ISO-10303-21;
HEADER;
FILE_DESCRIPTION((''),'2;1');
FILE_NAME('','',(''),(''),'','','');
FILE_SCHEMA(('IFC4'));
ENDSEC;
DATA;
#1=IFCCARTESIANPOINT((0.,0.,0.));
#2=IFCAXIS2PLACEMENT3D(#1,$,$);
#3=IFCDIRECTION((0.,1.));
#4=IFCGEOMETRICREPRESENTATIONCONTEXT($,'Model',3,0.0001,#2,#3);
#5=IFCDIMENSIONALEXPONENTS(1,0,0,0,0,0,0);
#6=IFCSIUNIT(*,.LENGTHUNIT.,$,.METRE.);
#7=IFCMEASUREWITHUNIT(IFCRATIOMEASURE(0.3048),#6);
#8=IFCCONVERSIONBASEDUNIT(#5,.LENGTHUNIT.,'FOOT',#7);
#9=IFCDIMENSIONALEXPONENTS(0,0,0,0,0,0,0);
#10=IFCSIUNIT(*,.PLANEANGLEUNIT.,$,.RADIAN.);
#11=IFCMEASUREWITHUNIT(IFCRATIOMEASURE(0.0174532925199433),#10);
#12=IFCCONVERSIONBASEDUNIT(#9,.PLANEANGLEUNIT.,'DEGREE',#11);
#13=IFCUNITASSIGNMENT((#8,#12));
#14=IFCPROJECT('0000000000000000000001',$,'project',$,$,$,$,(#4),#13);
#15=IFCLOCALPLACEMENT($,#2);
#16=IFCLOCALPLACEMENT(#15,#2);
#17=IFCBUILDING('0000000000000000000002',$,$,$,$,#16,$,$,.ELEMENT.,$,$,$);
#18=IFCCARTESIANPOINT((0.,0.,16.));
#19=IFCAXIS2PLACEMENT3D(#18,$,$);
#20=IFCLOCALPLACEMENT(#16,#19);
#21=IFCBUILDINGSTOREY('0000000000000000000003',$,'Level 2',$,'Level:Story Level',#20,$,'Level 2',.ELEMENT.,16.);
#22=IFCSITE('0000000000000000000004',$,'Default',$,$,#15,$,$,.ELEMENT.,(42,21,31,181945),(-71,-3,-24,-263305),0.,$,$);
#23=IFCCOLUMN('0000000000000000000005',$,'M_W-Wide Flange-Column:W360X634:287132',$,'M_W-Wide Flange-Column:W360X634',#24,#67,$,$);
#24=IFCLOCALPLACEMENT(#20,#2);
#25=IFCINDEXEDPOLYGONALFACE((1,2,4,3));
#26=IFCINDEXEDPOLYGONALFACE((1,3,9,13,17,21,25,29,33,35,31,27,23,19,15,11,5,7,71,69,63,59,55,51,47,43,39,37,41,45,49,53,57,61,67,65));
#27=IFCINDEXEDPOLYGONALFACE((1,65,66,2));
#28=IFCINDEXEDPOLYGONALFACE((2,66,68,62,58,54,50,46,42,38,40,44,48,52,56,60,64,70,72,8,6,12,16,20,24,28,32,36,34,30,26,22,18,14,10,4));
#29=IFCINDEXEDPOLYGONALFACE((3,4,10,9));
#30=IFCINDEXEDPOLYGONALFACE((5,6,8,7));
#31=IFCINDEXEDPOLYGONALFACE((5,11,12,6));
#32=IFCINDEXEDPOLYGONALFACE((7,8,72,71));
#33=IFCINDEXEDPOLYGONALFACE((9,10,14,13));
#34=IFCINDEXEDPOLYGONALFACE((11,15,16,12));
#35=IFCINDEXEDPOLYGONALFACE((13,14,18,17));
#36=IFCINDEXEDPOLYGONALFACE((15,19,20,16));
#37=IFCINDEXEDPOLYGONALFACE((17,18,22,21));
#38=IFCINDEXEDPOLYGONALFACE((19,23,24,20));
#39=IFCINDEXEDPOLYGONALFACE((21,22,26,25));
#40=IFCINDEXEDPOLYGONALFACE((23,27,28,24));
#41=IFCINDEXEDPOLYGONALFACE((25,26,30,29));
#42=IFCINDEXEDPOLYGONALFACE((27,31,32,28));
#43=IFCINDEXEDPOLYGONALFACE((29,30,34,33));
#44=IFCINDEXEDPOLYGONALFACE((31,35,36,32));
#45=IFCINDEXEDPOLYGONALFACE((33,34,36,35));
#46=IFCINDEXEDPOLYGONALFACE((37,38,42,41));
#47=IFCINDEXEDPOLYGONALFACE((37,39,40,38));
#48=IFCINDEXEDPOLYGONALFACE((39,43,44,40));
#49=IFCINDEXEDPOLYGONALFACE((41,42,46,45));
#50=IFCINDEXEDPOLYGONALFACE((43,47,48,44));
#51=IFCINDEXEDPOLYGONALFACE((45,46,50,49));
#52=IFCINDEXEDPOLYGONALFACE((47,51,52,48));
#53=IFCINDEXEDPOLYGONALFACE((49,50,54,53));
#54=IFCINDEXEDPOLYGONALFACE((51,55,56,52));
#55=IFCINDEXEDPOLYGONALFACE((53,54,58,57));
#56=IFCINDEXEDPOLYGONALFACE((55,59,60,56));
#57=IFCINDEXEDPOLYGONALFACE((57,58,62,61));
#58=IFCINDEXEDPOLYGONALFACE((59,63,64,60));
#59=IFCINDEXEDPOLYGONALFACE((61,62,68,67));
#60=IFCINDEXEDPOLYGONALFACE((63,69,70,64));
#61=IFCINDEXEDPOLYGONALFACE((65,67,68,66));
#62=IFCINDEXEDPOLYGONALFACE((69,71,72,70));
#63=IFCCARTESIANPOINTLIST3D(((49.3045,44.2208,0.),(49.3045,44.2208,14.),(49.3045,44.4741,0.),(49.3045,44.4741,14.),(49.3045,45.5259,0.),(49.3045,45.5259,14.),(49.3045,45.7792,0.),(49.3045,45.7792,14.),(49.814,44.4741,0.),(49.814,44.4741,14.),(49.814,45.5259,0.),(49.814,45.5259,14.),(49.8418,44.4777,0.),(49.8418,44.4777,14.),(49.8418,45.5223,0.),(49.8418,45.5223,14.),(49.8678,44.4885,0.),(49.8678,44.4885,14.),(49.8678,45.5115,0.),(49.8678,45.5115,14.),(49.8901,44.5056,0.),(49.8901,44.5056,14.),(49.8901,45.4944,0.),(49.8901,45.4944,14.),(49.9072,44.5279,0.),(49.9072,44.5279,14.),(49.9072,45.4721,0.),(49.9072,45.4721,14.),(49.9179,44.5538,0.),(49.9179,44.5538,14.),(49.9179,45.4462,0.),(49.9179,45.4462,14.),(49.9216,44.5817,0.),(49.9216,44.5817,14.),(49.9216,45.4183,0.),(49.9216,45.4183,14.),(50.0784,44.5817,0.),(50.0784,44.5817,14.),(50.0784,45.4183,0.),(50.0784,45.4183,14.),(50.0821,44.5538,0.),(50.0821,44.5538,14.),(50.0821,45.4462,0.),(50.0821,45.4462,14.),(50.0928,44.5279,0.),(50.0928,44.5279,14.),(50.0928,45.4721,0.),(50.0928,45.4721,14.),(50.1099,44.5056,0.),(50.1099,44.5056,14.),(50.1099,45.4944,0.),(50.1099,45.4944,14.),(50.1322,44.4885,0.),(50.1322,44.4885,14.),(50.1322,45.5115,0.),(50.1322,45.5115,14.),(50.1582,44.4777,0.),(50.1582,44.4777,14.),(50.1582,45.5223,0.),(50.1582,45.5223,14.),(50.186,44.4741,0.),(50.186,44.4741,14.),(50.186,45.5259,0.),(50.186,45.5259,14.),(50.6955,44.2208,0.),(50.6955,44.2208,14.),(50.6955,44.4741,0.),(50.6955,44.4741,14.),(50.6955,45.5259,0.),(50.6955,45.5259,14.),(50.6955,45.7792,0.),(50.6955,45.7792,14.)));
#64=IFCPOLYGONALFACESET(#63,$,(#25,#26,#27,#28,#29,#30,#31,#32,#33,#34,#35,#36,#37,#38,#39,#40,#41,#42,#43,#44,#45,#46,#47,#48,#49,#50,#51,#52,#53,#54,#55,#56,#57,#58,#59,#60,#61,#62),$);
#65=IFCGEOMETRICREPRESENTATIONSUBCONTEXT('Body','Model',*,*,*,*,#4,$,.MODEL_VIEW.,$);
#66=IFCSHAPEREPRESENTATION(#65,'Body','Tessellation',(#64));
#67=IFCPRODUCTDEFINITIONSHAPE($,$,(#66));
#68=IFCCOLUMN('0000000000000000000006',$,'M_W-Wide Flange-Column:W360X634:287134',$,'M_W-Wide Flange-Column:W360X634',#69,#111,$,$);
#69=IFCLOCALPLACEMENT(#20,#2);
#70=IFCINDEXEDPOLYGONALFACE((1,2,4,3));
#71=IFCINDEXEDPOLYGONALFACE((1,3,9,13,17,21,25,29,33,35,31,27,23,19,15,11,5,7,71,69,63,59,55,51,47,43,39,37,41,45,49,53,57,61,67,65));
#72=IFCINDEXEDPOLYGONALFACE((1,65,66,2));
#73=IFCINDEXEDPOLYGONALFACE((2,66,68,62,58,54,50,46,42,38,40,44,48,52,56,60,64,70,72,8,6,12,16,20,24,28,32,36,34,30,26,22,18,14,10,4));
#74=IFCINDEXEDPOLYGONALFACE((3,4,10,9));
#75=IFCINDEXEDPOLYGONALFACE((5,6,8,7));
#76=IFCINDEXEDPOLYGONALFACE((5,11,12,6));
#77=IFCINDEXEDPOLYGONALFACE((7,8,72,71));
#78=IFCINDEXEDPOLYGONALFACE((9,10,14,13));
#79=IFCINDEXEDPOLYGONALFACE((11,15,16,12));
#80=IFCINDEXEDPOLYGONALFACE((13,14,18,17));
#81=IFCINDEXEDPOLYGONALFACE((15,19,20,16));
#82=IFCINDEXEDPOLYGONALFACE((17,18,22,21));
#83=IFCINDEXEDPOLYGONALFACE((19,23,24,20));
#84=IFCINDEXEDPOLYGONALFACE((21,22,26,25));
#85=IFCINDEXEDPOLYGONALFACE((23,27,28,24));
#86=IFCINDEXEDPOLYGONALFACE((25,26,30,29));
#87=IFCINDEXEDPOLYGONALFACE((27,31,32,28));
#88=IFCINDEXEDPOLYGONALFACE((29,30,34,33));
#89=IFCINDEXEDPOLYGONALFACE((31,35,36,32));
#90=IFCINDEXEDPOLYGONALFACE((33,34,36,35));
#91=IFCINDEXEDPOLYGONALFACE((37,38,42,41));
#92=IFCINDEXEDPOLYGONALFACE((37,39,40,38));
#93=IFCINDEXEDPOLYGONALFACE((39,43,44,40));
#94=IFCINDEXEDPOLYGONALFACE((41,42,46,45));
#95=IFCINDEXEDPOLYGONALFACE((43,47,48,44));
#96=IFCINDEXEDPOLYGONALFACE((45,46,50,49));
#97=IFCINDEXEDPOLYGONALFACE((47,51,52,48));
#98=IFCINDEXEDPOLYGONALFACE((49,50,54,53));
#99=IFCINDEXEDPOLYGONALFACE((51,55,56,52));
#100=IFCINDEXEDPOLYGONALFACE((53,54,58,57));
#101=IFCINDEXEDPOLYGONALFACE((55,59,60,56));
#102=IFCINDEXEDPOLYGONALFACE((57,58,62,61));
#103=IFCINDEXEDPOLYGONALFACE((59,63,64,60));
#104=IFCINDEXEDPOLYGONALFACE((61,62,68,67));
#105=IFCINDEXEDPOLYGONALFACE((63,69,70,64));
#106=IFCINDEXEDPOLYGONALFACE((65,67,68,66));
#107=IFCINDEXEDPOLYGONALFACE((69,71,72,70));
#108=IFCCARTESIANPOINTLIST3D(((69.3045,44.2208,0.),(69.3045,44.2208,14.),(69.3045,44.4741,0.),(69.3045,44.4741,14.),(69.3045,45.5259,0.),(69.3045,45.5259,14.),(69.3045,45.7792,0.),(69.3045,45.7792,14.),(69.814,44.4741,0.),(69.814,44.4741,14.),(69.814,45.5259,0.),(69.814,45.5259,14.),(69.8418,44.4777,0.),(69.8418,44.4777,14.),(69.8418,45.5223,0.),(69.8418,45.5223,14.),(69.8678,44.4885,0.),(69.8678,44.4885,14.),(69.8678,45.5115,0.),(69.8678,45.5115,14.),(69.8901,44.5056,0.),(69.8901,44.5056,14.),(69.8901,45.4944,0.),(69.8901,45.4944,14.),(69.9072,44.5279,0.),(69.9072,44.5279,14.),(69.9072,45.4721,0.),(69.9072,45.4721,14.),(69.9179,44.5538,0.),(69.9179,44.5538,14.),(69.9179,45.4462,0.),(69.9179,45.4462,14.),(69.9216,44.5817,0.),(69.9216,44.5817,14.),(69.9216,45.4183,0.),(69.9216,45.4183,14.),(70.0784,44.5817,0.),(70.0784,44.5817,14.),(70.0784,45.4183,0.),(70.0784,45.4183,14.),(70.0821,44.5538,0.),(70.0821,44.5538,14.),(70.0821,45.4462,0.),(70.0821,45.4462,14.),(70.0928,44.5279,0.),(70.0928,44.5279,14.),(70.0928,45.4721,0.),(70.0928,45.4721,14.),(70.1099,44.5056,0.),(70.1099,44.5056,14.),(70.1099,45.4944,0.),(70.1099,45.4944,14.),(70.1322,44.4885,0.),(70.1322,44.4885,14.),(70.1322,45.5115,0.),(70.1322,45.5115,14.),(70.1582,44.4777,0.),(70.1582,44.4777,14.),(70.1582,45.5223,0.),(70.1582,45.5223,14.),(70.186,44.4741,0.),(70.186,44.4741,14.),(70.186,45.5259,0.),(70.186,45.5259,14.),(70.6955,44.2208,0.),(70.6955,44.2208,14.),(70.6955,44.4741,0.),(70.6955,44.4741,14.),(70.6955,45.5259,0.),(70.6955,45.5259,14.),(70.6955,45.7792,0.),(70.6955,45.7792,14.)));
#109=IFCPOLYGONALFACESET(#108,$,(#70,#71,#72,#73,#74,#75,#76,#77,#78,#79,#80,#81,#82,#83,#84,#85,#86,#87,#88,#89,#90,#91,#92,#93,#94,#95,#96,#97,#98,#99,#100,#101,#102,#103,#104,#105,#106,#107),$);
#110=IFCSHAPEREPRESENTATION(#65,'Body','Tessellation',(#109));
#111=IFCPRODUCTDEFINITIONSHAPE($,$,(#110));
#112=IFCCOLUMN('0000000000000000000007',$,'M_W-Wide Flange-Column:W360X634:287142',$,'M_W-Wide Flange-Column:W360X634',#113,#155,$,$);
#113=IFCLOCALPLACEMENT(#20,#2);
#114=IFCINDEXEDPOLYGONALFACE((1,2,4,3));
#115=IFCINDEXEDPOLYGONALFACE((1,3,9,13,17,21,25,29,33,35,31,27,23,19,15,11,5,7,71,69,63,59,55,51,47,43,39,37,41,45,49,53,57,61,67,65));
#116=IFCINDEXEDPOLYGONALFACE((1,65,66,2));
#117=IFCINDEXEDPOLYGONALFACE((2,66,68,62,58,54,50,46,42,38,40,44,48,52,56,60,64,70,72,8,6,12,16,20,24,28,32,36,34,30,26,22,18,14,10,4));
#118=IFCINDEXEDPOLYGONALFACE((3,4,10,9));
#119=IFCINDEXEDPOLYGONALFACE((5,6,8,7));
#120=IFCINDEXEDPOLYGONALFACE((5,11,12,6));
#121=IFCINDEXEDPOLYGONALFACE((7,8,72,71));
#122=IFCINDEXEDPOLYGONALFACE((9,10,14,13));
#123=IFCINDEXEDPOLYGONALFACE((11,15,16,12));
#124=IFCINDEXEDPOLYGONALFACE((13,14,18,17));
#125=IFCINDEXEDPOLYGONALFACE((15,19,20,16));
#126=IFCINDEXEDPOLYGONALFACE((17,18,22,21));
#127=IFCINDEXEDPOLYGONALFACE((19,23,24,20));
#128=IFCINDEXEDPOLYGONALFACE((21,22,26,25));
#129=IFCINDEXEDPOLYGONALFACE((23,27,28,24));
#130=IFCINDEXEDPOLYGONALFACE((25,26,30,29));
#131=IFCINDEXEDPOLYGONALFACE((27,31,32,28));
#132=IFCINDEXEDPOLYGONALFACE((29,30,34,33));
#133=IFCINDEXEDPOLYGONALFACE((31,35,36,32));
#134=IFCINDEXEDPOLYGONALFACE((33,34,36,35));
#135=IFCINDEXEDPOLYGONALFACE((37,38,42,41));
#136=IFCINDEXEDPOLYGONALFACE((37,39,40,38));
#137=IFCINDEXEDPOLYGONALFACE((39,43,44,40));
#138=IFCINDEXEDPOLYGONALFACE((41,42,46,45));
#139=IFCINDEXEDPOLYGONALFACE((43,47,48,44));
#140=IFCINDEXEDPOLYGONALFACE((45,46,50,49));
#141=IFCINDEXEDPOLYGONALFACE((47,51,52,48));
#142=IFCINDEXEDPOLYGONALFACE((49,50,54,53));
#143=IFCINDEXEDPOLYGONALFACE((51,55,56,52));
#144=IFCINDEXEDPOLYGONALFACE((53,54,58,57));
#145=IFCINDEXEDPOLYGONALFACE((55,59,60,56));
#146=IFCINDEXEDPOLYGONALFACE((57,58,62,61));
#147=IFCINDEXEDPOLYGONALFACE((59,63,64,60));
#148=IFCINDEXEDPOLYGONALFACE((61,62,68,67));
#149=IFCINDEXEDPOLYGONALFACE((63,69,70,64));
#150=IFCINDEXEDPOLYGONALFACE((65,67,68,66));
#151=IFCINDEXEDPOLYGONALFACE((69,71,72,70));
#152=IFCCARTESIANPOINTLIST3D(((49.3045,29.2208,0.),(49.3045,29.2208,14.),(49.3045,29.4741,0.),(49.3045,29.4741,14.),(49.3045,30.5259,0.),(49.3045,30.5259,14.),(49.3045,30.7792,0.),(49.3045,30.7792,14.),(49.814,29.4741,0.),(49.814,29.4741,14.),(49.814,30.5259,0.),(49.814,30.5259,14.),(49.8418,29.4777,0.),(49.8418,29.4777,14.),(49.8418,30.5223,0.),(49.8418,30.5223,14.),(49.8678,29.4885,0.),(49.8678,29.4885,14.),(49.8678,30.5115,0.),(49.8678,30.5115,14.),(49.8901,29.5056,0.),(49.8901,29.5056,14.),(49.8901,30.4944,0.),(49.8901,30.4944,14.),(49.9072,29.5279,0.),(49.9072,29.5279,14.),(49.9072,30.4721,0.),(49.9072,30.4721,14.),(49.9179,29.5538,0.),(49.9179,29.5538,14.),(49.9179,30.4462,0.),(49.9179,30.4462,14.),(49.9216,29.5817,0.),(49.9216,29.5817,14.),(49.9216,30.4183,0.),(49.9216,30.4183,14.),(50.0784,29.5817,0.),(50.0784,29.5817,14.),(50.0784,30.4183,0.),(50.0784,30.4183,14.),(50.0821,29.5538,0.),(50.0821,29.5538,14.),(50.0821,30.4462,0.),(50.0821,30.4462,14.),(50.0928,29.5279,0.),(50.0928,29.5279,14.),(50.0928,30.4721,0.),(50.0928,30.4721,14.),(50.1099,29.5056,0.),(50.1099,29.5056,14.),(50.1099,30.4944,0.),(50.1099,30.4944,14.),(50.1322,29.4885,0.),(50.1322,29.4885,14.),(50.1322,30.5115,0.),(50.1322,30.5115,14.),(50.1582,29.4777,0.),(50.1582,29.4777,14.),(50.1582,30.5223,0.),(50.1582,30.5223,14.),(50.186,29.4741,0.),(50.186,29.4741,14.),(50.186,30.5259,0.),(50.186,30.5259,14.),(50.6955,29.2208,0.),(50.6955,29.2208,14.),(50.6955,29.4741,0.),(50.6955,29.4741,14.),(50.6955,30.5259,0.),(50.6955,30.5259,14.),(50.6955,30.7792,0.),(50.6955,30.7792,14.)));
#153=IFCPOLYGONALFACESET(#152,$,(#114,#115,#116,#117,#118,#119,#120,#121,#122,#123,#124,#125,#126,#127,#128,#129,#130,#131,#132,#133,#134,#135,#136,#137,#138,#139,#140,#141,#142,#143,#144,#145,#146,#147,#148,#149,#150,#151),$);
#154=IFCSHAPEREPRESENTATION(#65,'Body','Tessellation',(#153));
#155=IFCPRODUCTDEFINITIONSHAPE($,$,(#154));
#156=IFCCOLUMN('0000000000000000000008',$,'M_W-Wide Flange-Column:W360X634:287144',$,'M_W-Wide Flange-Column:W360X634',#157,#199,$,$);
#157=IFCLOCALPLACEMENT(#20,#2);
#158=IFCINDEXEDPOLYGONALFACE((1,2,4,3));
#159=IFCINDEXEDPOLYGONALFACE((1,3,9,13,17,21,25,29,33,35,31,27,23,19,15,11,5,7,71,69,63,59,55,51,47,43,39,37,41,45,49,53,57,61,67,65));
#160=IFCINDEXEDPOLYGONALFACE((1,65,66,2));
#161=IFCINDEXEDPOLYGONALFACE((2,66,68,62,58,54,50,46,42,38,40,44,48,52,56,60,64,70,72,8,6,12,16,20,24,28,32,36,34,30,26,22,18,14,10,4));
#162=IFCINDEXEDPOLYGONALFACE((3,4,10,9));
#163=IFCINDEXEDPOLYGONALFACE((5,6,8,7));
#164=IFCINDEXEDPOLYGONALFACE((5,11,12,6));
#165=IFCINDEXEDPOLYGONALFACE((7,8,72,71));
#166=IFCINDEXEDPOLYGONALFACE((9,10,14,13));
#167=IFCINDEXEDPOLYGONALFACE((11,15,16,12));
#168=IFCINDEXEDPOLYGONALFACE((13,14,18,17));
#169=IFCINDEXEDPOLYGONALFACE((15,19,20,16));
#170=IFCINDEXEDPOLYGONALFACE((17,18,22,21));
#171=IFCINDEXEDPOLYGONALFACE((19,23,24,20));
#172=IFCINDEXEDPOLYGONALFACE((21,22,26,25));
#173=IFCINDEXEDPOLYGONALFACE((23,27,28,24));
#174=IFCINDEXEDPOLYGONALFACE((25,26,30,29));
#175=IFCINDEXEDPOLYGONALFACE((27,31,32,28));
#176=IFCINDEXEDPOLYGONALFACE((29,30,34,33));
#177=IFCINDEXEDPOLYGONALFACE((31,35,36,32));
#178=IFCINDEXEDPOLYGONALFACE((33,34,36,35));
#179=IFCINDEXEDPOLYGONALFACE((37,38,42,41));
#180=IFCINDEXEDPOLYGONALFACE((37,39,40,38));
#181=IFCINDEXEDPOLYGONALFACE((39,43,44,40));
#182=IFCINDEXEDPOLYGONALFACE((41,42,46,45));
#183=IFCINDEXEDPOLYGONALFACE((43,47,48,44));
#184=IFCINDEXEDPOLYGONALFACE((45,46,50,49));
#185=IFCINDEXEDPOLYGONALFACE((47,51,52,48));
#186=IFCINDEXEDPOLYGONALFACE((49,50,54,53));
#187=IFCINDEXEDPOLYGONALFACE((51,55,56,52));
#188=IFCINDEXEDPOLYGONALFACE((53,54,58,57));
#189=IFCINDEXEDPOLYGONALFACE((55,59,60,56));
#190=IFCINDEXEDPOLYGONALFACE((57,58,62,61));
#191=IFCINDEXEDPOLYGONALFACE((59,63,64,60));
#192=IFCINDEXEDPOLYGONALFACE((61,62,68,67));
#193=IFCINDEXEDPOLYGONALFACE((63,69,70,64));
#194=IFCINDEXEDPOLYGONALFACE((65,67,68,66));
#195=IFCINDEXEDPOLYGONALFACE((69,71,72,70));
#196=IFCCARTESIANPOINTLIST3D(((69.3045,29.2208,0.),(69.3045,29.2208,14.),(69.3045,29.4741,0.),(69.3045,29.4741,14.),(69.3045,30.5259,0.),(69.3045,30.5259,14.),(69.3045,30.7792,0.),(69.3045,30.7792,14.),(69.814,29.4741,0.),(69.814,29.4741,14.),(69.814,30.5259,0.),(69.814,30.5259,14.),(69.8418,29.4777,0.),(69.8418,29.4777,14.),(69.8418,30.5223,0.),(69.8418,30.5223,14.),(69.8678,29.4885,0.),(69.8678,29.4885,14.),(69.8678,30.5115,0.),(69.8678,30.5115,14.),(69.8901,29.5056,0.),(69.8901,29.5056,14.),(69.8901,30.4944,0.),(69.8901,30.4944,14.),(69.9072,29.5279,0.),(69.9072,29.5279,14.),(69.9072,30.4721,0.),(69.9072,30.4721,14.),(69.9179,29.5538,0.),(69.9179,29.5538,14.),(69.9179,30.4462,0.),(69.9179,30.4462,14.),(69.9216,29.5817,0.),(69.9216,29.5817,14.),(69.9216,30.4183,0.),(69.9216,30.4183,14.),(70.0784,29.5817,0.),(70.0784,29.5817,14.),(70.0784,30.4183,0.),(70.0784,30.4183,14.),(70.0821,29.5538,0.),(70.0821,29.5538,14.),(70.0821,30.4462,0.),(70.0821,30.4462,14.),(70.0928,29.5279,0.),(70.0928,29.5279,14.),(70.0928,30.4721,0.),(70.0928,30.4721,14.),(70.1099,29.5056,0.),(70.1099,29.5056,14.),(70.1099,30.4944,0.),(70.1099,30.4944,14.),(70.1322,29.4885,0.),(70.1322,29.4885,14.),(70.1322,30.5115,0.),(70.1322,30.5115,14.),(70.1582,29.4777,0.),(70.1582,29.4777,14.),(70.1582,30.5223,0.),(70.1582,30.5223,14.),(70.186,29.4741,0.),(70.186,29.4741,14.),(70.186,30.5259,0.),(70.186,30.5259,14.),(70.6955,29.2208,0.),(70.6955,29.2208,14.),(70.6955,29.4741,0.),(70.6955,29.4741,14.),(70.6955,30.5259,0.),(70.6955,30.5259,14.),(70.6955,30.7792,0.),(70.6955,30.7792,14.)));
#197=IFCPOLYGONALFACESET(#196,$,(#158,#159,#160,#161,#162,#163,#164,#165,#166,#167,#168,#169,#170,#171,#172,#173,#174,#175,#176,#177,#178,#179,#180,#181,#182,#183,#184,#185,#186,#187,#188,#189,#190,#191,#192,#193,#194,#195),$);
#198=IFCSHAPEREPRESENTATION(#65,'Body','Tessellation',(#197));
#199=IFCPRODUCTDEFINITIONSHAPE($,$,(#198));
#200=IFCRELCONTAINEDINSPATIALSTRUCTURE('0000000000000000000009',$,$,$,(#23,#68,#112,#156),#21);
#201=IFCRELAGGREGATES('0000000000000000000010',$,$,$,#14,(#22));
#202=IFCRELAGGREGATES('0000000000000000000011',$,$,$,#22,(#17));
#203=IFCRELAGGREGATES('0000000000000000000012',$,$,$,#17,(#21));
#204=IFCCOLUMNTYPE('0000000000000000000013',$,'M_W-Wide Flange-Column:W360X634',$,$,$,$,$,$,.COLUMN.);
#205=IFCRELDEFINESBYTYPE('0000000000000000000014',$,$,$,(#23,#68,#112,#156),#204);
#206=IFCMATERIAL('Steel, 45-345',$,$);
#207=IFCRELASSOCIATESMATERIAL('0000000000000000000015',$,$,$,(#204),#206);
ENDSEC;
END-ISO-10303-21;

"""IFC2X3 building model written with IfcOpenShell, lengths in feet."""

from ifc_helpers import new_model, entity, si_unit, converted_unit, direction, frame, frame_2d, origin, place, context, subcontext, project, spatial, polyline, circle_curve, parameter, trimmed, segment, composite_curve, outline, extrude, source, transform, mapped, material, type_object, type_shapes, element, save


model = new_model("IFC2X3")

# Units and contexts
model_context = context("Model", 3, precision=0.0001, world=origin(), true_north=direction((0.0, 1.0)))
body_context = subcontext(model_context, "Body", "Model", "MODEL_VIEW")
ifc_project = project(units=[converted_unit("LENGTHUNIT", "FOOT", entity("IfcRatioMeasure", 0.3048), si_unit("LENGTHUNIT", "METRE"), dimensions=[1, 0, 0, 0, 0, 0, 0]), converted_unit("PLANEANGLEUNIT", "DEGREE", entity("IfcRatioMeasure", 0.0174532925199433), si_unit("PLANEANGLEUNIT", "RADIAN"), dimensions=[0, 0, 0, 0, 0, 0, 0])], contexts=[model_context])

# Site, building, storey
site_placement = place(None, origin())
site = spatial("IfcSite", under=ifc_project, at=site_placement, Name="Default", CompositionType="ELEMENT", RefLatitude=(42, 21, 31, 181945), RefLongitude=(-71, -3, -24, -263305), RefElevation=0.0)
building_placement = place(site_placement, origin())
building = spatial("IfcBuilding", under=site, at=building_placement, CompositionType="ELEMENT")
storey_placement = place(building_placement, frame((0.0, 0.0, 16.0)))
storey = spatial("IfcBuildingStorey", under=building, at=storey_placement, Name="Level 2", ObjectType="Level:Story Level", LongName="Level 2", CompositionType="ELEMENT", Elevation=16.0)

# Columns
ifc_material = material(Name="Steel, 45-345")
column_type = type_object("IfcColumnType", Name="M_W-Wide Flange-Column:W360X634", PredefinedType="COLUMN", material=ifc_material)
shared_shape = source(origin(), body_context, "Body", "SweptSolid", [
    extrude(outline(composite_curve([segment(polyline([(0.5259, -0.6955), (0.7792, -0.6955)]), True, "CONTINUOUS"), segment(polyline([(0.7792, -0.6955), (0.7792, 0.6955)]), True, "CONTINUOUS"), segment(polyline([(0.7792, 0.6955), (0.5259, 0.6955)]), True, "CONTINUOUS"), segment(polyline([(0.5259, 0.6955), (0.5259, 0.186)]), True, "CONTINUOUS"), segment(trimmed(circle_curve(frame_2d((0.4183, 0.186), x_axis=(1.0, 0.0)), 0.1076), [parameter(270.0)], [parameter(0.0)], True, "PARAMETER"), False, "CONTINUOUS"), segment(polyline([(0.4183, 0.0784), (-0.4183, 0.0784)]), True, "CONTINUOUS"), segment(trimmed(circle_curve(frame_2d((-0.4183, 0.186), x_axis=(0.0, -1.0)), 0.1076), [parameter(270.0)], [parameter(0.0)], True, "PARAMETER"), False, "CONTINUOUS"), segment(polyline([(-0.5259, 0.186), (-0.5259, 0.6955)]), True, "CONTINUOUS"), segment(polyline([(-0.5259, 0.6955), (-0.7792, 0.6955)]), True, "CONTINUOUS"), segment(polyline([(-0.7792, 0.6955), (-0.7792, -0.6955)]), True, "CONTINUOUS"), segment(polyline([(-0.7792, -0.6955), (-0.5259, -0.6955)]), True, "CONTINUOUS"), segment(polyline([(-0.5259, -0.6955), (-0.5259, -0.186)]), True, "CONTINUOUS"), segment(trimmed(circle_curve(frame_2d((-0.4183, -0.186), x_axis=(-1.0, 0.0)), 0.1076), [parameter(270.0)], [parameter(0.0)], True, "PARAMETER"), False, "CONTINUOUS"), segment(polyline([(-0.4183, -0.0784), (0.4183, -0.0784)]), True, "CONTINUOUS"), segment(trimmed(circle_curve(frame_2d((0.4183, -0.186), x_axis=(0.0, 1.0)), 0.1076), [parameter(270.0)], [parameter(0.0)], True, "PARAMETER"), False, "CONTINUOUS"), segment(polyline([(0.5259, -0.186), (0.5259, -0.6955)]), True, "CONTINUOUS")], self_intersect=False)), frame((0.0, 0.0, 16.0), z_axis=(0.0, 0.0, 1.0), x_axis=(0.0, -1.0, 0.0)), (0.0, 0.0, 1.0), 14.0),
])
type_shapes(column_type, [shared_shape])
for number, where, name in (
    (1, (50.0, 45.0, -16.0), "M_W-Wide Flange-Column:W360X634:287132"),
    (2, (70.0, 45.0, -16.0), "M_W-Wide Flange-Column:W360X634:287134"),
    (3, (50.0, 30.0, -16.0), "M_W-Wide Flange-Column:W360X634:287142"),
    (4, (70.0, 30.0, -16.0), "M_W-Wide Flange-Column:W360X634:287144"),
):
    element("IfcColumn", number, at=place(storey_placement, frame(where)), inside=storey, type_object=column_type, Name=name, ObjectType="M_W-Wide Flange-Column:W360X634", context=body_context, shape_type="MappedRepresentation", body=[
        mapped(shared_shape, transform((0.0, 0.0, 0.0), scale=1.0)),
    ])

save(model, "model.ifc")
